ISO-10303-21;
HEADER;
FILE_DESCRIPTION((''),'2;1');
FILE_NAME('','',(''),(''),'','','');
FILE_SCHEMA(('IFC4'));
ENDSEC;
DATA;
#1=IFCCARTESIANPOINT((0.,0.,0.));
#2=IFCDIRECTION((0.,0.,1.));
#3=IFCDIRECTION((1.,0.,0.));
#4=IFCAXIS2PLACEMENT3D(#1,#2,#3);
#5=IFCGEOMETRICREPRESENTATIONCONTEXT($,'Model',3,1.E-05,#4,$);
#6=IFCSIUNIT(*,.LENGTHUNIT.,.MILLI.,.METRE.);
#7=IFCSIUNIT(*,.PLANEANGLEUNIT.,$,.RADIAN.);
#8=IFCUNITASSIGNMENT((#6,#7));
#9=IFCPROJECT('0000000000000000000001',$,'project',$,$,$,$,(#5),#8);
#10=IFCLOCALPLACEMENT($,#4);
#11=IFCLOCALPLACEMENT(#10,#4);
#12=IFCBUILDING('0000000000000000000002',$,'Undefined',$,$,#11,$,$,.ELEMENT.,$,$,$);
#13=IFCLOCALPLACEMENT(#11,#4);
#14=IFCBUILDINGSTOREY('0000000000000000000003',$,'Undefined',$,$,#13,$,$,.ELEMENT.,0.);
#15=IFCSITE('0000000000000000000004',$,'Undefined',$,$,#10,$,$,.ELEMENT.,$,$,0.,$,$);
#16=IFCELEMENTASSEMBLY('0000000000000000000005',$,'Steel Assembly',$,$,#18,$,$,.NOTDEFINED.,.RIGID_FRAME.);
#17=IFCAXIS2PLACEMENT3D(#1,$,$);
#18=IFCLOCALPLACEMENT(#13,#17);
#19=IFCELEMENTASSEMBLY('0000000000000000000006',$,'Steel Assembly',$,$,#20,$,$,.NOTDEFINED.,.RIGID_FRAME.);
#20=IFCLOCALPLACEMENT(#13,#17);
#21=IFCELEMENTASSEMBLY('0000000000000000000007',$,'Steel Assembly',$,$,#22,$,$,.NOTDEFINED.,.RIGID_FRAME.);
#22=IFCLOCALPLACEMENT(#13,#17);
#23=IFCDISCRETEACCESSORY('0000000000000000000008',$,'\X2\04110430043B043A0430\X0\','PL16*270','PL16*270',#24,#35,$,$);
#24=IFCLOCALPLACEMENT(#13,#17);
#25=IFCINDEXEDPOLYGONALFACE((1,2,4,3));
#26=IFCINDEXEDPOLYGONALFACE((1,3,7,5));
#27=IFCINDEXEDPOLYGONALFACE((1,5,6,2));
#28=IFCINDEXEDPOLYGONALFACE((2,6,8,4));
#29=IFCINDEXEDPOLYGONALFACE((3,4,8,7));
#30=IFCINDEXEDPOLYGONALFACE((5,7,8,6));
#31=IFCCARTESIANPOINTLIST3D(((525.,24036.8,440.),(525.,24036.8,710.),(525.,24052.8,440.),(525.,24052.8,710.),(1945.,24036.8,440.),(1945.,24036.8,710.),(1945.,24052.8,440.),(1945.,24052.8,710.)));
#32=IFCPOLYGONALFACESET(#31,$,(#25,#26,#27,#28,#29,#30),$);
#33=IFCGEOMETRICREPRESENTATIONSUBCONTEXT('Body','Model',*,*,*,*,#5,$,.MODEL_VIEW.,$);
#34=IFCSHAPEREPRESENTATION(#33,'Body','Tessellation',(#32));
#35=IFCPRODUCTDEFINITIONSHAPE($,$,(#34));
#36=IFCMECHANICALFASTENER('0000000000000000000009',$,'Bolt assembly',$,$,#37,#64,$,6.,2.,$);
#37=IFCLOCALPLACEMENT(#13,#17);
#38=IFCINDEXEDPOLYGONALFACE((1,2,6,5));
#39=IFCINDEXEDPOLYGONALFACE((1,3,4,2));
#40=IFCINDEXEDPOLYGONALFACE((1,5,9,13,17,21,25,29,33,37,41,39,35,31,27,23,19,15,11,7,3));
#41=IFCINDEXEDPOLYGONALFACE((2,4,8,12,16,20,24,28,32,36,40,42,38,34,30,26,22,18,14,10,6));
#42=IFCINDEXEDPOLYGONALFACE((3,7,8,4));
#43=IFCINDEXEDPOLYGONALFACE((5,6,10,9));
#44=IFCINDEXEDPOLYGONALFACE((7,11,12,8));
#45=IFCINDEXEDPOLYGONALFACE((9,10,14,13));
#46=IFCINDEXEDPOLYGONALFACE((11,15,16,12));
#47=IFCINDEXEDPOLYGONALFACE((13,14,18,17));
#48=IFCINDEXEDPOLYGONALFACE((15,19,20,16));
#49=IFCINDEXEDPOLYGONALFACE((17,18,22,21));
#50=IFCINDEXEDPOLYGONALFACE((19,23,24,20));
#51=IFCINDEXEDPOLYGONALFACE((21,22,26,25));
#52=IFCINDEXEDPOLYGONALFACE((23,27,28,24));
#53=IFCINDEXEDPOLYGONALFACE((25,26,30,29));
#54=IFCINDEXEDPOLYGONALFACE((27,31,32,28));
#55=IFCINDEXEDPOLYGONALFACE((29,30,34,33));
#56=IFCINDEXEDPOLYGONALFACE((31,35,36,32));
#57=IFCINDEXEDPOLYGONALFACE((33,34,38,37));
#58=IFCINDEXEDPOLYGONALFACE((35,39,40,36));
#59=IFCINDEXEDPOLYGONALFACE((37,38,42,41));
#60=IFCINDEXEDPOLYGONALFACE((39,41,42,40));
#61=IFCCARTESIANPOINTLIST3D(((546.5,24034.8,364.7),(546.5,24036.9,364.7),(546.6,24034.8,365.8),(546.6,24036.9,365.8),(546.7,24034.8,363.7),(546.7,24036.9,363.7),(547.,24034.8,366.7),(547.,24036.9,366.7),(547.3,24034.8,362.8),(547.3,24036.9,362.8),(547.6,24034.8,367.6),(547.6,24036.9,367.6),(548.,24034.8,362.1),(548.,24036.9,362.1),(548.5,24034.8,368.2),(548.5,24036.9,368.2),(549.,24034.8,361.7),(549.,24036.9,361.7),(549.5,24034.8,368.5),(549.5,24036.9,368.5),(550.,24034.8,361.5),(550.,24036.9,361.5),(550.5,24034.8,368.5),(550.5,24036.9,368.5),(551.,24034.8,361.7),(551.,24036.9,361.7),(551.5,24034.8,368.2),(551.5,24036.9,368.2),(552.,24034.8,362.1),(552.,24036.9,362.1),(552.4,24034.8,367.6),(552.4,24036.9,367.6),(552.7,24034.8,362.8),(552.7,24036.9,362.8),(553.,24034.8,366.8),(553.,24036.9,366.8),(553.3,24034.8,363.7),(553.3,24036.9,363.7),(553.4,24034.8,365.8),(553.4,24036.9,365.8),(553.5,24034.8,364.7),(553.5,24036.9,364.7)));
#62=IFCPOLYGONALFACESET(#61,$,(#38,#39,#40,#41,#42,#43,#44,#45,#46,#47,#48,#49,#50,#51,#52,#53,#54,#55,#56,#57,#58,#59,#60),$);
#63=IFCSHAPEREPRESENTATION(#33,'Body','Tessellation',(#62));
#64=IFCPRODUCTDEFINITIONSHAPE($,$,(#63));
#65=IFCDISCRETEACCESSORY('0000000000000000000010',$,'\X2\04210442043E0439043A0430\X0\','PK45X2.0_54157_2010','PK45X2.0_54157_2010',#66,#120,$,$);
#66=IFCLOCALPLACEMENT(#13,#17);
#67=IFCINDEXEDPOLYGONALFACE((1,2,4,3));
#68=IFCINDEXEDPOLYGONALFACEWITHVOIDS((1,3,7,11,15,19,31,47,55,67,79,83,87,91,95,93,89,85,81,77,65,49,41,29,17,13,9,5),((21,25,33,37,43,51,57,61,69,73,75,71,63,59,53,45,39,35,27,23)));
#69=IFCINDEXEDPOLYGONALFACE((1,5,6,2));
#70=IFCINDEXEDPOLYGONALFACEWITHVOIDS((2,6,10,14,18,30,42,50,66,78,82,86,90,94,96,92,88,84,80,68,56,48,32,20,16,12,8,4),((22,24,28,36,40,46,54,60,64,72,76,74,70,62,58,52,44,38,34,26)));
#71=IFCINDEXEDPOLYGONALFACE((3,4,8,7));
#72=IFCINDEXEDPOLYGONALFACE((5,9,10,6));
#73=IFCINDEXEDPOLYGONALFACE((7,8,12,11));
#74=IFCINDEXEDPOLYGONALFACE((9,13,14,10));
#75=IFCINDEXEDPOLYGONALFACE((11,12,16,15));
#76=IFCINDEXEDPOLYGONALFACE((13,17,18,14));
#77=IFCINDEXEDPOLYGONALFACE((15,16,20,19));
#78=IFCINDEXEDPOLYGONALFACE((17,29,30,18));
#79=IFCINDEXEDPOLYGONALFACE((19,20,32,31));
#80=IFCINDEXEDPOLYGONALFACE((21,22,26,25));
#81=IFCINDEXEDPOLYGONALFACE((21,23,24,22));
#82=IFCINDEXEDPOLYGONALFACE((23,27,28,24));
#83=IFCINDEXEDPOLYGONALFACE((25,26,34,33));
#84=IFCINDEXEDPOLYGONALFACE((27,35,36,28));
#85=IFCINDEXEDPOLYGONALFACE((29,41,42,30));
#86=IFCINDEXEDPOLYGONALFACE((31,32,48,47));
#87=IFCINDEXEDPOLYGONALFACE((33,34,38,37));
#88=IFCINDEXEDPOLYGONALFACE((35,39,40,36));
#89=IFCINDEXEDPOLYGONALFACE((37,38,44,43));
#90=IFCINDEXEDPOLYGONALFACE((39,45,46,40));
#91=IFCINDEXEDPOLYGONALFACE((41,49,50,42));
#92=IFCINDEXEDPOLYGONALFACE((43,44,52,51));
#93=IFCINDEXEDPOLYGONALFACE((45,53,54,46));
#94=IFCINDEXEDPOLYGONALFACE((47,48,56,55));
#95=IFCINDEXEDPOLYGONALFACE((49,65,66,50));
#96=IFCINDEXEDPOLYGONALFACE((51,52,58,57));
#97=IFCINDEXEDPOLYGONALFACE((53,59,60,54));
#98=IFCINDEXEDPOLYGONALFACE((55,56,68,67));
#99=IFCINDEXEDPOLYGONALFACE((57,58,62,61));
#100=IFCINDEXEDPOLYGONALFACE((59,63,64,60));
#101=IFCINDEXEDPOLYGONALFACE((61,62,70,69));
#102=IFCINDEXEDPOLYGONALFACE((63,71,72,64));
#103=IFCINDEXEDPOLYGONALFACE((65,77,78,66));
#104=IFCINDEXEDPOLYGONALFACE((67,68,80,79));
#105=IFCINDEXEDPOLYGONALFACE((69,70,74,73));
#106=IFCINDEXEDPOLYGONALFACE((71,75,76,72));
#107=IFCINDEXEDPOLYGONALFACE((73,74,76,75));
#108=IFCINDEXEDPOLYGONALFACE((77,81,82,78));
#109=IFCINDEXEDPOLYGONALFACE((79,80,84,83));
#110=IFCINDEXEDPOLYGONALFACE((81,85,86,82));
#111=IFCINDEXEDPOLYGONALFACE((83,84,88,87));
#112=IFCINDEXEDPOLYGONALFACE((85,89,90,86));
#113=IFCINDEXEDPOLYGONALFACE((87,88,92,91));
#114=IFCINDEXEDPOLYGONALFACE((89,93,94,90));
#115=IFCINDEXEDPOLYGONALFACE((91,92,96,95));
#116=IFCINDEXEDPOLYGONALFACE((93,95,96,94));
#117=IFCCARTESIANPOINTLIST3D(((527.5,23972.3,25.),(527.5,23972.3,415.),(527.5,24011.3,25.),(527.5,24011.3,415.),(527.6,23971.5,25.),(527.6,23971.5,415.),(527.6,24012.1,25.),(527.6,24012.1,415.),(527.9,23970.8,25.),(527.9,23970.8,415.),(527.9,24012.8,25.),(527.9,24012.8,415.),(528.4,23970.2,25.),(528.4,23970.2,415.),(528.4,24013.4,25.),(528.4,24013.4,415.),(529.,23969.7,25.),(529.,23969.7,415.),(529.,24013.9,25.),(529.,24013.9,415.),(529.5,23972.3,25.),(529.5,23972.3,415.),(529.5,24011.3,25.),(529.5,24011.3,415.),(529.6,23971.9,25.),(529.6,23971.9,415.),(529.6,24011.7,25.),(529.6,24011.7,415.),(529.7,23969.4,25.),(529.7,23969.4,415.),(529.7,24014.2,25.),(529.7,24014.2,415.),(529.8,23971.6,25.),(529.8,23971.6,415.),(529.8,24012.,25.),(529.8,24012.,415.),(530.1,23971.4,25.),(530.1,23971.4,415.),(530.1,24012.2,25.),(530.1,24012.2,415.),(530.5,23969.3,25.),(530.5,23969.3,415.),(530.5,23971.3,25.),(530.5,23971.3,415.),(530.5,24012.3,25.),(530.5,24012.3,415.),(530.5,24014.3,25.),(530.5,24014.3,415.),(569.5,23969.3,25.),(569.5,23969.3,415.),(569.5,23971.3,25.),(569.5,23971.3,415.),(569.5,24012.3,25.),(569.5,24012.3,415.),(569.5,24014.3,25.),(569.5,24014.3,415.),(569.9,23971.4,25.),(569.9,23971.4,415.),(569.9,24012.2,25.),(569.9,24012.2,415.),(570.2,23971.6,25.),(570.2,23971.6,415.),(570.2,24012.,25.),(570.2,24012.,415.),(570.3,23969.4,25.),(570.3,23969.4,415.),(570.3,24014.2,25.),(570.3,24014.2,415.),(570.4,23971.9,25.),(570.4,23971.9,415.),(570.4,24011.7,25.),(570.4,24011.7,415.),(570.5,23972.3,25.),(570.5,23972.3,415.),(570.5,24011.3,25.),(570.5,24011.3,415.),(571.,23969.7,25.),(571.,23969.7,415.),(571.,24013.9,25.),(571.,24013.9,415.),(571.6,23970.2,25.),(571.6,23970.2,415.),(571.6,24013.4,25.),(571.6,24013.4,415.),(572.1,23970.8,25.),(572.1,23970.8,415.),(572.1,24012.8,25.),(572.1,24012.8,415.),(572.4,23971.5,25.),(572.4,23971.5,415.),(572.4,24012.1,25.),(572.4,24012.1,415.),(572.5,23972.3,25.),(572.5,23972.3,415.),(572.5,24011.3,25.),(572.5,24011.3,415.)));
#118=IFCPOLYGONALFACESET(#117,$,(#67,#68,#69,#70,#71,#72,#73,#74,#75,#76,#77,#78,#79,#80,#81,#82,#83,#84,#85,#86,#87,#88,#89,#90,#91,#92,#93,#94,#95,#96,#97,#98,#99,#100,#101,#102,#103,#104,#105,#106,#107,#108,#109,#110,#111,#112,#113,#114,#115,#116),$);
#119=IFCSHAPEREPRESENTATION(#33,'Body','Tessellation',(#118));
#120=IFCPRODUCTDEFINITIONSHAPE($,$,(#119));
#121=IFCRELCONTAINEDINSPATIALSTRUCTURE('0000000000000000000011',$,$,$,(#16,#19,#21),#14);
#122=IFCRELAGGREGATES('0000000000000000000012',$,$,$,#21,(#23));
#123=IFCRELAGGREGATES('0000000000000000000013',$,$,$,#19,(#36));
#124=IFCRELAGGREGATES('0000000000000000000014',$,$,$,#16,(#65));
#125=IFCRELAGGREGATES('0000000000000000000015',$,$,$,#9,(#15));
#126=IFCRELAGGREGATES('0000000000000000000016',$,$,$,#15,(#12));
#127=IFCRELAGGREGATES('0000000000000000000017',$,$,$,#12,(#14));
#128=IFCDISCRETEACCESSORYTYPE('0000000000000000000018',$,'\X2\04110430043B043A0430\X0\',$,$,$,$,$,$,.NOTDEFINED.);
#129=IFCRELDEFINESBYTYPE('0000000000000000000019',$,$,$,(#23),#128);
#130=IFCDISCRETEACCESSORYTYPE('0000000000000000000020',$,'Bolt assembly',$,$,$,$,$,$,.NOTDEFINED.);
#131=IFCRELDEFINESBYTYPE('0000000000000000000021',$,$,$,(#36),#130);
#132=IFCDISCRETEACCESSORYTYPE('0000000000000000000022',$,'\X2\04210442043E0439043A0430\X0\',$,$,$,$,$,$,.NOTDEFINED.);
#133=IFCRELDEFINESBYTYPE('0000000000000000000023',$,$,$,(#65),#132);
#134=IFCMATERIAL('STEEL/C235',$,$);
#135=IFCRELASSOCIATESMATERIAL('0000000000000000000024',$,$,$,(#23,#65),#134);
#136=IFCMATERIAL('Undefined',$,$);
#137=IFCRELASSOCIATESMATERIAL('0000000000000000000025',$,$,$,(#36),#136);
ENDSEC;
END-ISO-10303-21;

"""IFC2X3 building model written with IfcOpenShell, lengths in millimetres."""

from ifc_helpers import new_model, si_unit, frame, origin_with_axes, origin_2d_with_axis, place, context, subcontext, project, spatial, polyline, hollow_rectangle, circle, outline, extrude, clip, halfspace, source, transform, mapped, material, type_object, element, aggregate, save


model = new_model("IFC2X3")

# Units and contexts
model_context = context("Model", 3, precision=1e-05, world=origin_with_axes())
body_context = subcontext(model_context, "Body", "Model", "MODEL_VIEW")
ifc_project = project(units=[si_unit("LENGTHUNIT", "METRE", prefix="MILLI"), si_unit("PLANEANGLEUNIT", "RADIAN")], contexts=[model_context])

# Site, building, storey
site_placement = place(None, origin_with_axes())
site = spatial("IfcSite", under=ifc_project, at=site_placement, Name="Undefined", CompositionType="ELEMENT", RefElevation=0.0)
building_placement = place(site_placement, origin_with_axes())
building = spatial("IfcBuilding", under=site, at=building_placement, Name="Undefined", CompositionType="ELEMENT")
storey_placement = place(building_placement, origin_with_axes())
storey = spatial("IfcBuildingStorey", under=building, at=storey_placement, Name="Undefined", CompositionType="ELEMENT", Elevation=0.0)

# Element assemblies
ifc_material_1 = material(Name="STEEL/C235")
assembly_1_placement = place(storey_placement, origin_with_axes())
assembly_1 = element("IfcElementAssembly", 1, at=assembly_1_placement, inside=storey, Name="Steel Assembly", AssemblyPlace="NOTDEFINED", PredefinedType="RIGID_FRAME")
assembly_2_placement = place(storey_placement, origin_with_axes())
assembly_2 = element("IfcElementAssembly", 2, at=assembly_2_placement, inside=storey, Name="Steel Assembly", AssemblyPlace="NOTDEFINED", PredefinedType="RIGID_FRAME")

# Element assembly, discrete accessory
discrete_accessory_type_1 = type_object("IfcDiscreteAccessoryType", Name="Балка")
assembly_3_placement = place(storey_placement, origin_with_axes())
assembly_3 = element("IfcElementAssembly", 3, at=assembly_3_placement, inside=storey, Name="Steel Assembly", AssemblyPlace="NOTDEFINED", PredefinedType="RIGID_FRAME")
discrete_accessory_1_placement = place(assembly_3_placement, frame((525.0, 24044.8, 575.0), z_axis=(0.0, -1.0, 0.0), x_axis=(1.0, 0.0, 0.0)))
discrete_accessory_1 = element("IfcDiscreteAccessory", 4, at=discrete_accessory_1_placement, type_object=discrete_accessory_type_1, material=ifc_material_1, Name="Балка", Description="PL16*270", ObjectType="PL16*270", context=body_context, shape_type="SweptSolid", body=[
    extrude(outline(polyline([(0.0, -135.0), (0.0, 135.0), (1420.0, 135.0), (1420.0, -135.0), (0.0, -135.0)])), frame((0.0, 0.0, -8.0), z_axis=(0.0, 0.0, 1.0), x_axis=(1.0, 0.0, 0.0)), (0.0, 0.0, 1.0), 16.0),
])
aggregate(assembly_3, [discrete_accessory_1])

# Mechanical fastener
ifc_material_2 = material(Name="Undefined")
discrete_accessory_type_2 = type_object("IfcDiscreteAccessoryType", Name="Bolt assembly")
shared_shape = source(origin_with_axes(), body_context, "Body", "SweptSolid", [
    extrude(circle(Radius=3.5, at=origin_2d_with_axis()), frame((0.0, -2.0, 0.0), z_axis=(0.0, 1.0, 0.0), x_axis=(1.0, 0.0, 0.0)), (0.0, 0.0, 1.0), 2.1),
])
mechanical_fastener_placement = place(assembly_2_placement, frame((550.0, 24036.8, 365.0), z_axis=(1.0, 0.0, 0.0), x_axis=(0.0, 0.0, -1.0)))
mechanical_fastener = element("IfcMechanicalFastener", 5, at=mechanical_fastener_placement, type_object=discrete_accessory_type_2, material=ifc_material_2, Name="Bolt assembly", NominalDiameter=6.0, NominalLength=2.0, context=body_context, shape_type="MappedRepresentation", body=[
    mapped(shared_shape, transform((0.0, 0.0, 0.0))),
])
aggregate(assembly_2, [mechanical_fastener])

# Discrete accessory
discrete_accessory_type_3 = type_object("IfcDiscreteAccessoryType", Name="Стойка")
discrete_accessory_2_placement = place(assembly_1_placement, frame((550.0, 23991.8, 415.0), z_axis=(-1.0, 0.0, 0.0), x_axis=(0.0, 0.0, -1.0)))
discrete_accessory_2 = element("IfcDiscreteAccessory", 6, at=discrete_accessory_2_placement, type_object=discrete_accessory_type_3, material=ifc_material_1, Name="Стойка", Description="PK45X2.0_54157_2010", ObjectType="PK45X2.0_54157_2010", context=body_context, shape_type="Clipping", body=[
    clip(extrude(hollow_rectangle(XDim=45.0, YDim=45.0, WallThickness=2.0, InnerFilletRadius=1.0, OuterFilletRadius=3.0, at=origin_2d_with_axis()), frame((390.0, 0.0, 0.0), z_axis=(-1.0, 0.0, 0.0), x_axis=(0.0, -1.0, 0.0)), (0.0, 0.0, 1.0), 390.0), halfspace(frame((390.0, -37.5, 0.0), z_axis=(1.0, 0.0, 0.0), x_axis=(0.0, 0.0, 1.0)), False)),
])
aggregate(assembly_1, [discrete_accessory_2])

save(model, "model.ifc")
